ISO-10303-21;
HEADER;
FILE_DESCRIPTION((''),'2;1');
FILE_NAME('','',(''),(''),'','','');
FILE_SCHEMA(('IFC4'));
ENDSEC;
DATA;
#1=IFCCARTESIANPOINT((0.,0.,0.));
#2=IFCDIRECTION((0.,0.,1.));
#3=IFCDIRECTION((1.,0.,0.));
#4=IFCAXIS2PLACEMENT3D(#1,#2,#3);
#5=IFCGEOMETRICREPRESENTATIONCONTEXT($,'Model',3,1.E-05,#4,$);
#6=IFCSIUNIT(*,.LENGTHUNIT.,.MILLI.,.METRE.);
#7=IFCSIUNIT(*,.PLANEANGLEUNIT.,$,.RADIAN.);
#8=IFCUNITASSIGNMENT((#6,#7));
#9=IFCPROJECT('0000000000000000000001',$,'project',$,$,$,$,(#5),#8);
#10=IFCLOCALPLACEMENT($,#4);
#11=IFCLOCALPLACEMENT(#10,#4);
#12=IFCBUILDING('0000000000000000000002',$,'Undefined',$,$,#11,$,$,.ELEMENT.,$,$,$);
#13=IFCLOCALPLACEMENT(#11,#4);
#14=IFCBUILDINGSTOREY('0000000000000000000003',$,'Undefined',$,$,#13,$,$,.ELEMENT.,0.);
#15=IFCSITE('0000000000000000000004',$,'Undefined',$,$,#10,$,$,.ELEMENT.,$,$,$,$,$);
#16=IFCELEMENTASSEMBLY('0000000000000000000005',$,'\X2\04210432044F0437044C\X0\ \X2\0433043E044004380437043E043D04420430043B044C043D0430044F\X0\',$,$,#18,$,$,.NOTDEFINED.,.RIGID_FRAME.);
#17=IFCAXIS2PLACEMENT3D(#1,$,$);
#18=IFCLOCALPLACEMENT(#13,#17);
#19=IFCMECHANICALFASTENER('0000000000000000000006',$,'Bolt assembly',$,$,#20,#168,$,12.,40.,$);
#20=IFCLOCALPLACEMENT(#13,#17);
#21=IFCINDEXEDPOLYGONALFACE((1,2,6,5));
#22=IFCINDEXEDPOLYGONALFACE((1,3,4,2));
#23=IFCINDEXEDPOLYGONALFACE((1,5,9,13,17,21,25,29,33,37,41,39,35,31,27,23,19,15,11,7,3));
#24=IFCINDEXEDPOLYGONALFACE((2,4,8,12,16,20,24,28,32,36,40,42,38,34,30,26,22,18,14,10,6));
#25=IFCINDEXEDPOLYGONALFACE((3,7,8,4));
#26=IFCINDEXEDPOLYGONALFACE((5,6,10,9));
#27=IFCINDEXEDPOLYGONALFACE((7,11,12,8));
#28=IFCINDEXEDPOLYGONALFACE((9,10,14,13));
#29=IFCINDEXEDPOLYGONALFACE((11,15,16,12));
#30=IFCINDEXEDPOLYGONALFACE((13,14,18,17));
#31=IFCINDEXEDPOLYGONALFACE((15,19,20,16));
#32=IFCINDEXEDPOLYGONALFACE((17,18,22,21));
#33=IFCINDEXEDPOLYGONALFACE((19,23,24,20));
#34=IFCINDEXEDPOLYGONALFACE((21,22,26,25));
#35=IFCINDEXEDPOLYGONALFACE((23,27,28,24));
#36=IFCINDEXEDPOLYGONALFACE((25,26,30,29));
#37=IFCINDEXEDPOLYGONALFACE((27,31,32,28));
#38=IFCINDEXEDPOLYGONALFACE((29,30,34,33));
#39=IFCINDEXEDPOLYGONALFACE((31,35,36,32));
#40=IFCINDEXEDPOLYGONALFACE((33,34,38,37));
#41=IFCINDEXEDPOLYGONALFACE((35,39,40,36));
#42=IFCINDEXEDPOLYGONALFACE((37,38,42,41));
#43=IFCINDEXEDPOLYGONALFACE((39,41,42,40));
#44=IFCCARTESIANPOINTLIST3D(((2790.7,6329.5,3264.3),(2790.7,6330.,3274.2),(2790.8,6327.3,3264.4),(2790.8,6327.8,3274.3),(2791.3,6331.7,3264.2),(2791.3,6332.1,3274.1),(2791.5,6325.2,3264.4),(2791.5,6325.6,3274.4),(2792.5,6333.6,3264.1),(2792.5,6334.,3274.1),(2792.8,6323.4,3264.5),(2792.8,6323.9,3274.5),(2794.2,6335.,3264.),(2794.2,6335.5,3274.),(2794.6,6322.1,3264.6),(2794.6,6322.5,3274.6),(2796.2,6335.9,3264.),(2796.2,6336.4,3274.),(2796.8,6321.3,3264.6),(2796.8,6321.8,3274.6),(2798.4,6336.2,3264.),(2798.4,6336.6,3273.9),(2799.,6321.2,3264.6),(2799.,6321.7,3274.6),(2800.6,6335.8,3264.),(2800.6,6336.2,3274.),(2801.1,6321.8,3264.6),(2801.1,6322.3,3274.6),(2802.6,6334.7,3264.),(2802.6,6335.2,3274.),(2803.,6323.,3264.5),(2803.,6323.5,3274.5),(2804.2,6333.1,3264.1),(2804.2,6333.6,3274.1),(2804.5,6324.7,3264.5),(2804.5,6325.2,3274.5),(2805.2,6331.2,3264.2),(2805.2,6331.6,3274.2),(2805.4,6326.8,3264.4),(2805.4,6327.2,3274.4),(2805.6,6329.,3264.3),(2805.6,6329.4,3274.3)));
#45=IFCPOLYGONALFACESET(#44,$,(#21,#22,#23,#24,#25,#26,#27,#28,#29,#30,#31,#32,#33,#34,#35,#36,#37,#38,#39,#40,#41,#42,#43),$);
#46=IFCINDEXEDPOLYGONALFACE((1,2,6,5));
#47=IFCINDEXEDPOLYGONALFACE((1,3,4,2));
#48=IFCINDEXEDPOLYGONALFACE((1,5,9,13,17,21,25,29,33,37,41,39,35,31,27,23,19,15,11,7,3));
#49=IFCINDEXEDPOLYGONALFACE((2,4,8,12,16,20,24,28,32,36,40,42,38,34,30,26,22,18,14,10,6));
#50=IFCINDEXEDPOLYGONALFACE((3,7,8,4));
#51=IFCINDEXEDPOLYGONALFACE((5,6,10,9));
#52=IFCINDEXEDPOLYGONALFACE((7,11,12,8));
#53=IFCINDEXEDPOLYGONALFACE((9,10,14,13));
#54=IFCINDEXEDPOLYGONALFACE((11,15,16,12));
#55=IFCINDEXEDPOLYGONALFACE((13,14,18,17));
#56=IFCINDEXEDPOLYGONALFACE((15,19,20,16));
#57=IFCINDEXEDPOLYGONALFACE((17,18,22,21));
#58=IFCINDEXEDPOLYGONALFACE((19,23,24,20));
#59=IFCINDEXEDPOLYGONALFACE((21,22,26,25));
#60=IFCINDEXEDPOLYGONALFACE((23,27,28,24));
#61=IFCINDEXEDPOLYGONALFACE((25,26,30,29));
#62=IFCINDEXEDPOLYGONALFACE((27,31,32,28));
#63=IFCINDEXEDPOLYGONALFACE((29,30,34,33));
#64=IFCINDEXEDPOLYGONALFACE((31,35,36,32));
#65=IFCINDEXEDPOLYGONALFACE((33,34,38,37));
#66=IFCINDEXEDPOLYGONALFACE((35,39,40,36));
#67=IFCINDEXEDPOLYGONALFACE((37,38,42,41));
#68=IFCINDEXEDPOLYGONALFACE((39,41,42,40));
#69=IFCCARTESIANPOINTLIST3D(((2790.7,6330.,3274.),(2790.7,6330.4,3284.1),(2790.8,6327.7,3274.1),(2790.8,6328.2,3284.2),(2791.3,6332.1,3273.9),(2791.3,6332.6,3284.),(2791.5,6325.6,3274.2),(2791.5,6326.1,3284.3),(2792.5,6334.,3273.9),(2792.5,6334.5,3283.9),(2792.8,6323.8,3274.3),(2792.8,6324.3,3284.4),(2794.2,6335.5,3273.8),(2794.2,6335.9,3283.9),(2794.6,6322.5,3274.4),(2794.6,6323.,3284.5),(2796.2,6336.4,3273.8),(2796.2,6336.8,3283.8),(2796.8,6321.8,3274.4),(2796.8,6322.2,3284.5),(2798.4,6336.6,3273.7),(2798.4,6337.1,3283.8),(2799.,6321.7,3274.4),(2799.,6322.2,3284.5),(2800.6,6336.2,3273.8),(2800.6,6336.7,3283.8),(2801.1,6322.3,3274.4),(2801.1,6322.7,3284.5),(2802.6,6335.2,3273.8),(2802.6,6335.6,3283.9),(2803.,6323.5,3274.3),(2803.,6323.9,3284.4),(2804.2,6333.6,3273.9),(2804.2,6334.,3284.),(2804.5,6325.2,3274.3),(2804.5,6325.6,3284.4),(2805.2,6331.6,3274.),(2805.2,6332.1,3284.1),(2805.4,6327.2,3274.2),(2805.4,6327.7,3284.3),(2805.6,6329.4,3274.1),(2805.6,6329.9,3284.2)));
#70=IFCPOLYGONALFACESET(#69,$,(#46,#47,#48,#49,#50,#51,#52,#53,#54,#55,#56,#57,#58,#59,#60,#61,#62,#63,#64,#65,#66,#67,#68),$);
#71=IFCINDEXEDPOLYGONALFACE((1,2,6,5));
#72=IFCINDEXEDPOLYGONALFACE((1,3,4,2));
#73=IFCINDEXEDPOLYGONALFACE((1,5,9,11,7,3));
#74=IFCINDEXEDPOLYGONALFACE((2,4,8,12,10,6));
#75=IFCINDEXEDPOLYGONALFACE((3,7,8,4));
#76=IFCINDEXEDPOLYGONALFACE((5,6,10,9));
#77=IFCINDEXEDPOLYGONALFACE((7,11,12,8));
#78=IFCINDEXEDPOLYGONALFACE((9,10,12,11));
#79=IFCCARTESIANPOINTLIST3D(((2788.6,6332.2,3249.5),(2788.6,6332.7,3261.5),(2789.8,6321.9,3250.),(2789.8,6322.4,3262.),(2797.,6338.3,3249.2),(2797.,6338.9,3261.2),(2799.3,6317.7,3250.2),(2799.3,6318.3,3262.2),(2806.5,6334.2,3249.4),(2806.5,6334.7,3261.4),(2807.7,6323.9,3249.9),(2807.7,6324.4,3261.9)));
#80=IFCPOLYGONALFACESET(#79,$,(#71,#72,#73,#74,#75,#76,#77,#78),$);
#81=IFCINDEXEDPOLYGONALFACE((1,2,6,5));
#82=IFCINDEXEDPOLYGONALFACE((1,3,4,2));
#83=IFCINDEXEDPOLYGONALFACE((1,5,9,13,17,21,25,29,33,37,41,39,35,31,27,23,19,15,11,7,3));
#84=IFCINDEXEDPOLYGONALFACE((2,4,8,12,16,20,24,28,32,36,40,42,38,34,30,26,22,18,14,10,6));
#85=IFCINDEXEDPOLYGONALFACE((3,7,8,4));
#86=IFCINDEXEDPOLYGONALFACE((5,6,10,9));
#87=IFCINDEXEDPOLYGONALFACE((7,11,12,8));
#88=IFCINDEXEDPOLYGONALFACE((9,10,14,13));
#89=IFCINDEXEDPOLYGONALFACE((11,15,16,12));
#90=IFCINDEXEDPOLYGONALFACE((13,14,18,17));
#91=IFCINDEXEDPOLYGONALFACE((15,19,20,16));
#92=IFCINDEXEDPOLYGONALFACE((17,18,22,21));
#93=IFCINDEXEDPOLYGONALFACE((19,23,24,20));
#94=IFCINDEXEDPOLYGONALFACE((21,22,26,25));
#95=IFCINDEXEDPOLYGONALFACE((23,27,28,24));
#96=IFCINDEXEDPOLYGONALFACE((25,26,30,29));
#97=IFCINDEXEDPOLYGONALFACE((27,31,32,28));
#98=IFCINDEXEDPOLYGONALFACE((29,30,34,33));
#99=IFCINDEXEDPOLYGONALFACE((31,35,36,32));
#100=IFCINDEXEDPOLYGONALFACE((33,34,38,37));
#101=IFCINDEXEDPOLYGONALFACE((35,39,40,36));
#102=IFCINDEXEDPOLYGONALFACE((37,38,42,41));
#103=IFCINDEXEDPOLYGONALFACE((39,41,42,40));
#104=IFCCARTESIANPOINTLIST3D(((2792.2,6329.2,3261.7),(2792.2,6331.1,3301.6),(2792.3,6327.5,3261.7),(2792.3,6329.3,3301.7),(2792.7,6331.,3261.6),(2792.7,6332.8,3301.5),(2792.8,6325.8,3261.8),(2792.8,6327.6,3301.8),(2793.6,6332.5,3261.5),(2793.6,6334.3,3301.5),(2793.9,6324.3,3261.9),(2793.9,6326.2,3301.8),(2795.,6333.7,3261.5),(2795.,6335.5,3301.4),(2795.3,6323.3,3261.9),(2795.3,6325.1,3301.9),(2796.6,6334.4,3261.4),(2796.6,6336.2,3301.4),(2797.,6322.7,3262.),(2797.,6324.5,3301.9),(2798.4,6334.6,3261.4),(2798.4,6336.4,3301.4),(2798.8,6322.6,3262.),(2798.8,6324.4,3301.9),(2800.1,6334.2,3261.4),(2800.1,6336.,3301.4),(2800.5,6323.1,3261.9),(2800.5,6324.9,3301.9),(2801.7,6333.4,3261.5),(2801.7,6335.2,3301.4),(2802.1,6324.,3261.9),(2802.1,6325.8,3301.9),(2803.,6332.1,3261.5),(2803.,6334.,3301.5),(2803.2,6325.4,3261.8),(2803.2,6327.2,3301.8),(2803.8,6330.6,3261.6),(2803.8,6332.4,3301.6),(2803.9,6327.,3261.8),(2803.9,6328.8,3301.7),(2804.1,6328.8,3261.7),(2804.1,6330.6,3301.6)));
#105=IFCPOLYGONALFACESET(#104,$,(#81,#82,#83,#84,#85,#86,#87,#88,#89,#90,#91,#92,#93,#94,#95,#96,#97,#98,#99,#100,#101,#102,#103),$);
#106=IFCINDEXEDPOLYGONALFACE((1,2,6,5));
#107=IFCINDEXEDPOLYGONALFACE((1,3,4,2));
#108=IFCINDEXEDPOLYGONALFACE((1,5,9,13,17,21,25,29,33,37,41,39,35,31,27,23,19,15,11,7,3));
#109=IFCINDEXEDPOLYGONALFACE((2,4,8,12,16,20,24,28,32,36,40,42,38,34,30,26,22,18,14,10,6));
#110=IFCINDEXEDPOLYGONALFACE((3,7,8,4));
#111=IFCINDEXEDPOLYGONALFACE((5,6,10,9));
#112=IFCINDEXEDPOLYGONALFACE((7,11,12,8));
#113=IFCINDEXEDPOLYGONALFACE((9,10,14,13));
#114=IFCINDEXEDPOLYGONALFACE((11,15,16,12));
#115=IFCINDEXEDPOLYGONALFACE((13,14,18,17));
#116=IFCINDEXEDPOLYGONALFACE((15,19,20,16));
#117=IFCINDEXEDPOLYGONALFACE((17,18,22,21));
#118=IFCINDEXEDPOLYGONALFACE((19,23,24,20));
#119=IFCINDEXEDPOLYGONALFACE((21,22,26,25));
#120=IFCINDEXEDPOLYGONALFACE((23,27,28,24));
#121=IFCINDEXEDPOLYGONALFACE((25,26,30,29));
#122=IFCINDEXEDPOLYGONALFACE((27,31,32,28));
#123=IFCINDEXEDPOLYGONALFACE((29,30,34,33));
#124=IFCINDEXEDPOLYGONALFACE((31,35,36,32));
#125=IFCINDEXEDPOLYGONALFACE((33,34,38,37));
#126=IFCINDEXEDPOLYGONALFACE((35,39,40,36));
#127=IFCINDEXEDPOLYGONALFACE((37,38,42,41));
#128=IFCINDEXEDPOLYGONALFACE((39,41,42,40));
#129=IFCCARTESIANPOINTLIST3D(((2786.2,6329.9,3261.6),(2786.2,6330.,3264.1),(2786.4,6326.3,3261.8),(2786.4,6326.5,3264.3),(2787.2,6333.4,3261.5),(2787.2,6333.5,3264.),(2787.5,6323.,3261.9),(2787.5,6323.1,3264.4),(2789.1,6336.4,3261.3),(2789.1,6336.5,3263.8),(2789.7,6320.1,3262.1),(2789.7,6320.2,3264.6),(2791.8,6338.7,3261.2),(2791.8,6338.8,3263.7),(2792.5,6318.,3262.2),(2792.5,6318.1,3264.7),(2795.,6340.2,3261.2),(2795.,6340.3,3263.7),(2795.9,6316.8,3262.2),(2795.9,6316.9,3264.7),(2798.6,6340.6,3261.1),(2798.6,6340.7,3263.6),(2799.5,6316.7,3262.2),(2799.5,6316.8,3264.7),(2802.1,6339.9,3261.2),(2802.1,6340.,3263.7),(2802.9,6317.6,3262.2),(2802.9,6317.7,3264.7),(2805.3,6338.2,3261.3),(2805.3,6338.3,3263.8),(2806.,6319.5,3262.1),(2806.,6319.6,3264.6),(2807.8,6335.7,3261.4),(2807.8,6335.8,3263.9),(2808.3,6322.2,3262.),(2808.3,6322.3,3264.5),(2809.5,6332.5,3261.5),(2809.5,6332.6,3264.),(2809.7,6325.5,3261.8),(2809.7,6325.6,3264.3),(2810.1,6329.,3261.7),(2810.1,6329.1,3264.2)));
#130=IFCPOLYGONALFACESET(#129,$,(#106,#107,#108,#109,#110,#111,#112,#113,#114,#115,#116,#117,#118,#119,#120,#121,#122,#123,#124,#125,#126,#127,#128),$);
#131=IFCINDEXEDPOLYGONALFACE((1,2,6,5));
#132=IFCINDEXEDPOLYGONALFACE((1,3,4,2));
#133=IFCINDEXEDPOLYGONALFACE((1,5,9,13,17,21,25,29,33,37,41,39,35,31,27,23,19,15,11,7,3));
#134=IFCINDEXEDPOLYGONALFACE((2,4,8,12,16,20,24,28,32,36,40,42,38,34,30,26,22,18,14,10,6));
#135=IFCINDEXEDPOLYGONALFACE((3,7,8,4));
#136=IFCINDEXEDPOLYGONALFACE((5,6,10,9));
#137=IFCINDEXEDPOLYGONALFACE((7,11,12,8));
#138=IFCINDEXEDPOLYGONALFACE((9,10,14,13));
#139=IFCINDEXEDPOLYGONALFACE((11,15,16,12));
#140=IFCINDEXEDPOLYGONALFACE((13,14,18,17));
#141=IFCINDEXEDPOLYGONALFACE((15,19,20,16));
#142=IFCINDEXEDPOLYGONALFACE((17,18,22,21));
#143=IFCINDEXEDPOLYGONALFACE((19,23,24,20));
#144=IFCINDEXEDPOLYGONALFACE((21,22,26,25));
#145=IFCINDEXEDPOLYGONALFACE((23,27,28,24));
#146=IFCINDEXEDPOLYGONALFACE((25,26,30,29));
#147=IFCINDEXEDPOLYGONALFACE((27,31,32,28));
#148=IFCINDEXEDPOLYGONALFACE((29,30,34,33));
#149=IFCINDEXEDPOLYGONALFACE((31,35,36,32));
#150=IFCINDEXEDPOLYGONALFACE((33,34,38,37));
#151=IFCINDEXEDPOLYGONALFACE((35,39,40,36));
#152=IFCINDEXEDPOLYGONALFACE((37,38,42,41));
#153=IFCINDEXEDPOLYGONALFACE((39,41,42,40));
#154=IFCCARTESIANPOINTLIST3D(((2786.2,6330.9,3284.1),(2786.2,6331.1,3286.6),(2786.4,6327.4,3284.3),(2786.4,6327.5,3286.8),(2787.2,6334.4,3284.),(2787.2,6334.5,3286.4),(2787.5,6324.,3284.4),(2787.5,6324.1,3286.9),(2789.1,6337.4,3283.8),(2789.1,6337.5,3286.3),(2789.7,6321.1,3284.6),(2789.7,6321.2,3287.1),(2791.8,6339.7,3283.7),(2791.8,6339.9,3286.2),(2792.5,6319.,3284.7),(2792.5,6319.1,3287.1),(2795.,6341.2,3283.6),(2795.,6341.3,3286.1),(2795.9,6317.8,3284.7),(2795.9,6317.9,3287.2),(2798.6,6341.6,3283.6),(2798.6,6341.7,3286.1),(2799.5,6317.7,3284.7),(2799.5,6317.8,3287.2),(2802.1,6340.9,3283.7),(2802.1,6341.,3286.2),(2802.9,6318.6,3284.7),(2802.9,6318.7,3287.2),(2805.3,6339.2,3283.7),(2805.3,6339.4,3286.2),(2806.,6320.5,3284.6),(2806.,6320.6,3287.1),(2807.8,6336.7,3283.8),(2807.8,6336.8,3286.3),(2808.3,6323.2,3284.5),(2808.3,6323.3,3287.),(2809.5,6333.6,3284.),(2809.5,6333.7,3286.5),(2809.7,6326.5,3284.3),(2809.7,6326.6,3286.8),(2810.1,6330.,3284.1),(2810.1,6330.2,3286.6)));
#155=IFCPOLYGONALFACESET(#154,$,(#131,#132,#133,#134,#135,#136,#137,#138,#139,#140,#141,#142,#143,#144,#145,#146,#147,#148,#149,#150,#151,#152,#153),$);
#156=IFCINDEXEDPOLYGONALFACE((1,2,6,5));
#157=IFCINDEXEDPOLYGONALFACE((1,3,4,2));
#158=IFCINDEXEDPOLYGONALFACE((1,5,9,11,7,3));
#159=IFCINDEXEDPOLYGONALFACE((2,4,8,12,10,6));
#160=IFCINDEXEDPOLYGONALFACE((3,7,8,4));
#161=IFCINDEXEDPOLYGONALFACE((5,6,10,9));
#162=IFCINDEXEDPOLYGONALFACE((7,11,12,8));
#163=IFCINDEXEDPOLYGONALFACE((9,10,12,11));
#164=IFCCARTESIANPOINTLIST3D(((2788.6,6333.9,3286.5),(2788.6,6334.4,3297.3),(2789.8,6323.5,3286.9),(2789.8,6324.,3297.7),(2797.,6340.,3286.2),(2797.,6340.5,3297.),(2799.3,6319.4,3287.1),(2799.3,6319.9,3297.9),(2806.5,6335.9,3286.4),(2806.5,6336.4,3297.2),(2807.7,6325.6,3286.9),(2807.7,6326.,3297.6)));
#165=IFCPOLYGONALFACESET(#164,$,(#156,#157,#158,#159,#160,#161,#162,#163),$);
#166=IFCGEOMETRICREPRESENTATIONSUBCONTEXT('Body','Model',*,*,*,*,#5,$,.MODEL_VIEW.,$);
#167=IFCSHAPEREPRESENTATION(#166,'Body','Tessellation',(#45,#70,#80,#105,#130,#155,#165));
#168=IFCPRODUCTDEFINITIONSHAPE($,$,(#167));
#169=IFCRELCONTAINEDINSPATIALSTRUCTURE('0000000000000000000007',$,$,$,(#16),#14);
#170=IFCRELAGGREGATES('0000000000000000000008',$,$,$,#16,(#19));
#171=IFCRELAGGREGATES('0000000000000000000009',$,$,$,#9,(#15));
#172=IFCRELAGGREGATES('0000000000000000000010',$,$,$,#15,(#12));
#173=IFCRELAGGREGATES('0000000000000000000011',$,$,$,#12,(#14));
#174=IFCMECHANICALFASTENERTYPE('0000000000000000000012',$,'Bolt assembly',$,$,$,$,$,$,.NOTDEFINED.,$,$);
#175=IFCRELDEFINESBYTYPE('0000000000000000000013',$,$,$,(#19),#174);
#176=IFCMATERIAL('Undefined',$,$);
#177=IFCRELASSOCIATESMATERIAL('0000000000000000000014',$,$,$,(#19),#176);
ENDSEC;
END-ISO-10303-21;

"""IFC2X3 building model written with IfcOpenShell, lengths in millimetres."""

from ifc_helpers import new_model, si_unit, frame, origin_with_axes, origin_2d_with_axis, place, context, subcontext, project, spatial, polyline, circle, outline, extrude, source, transform, mapped, material, type_object, element, aggregate, save


model = new_model("IFC2X3")

# Units and contexts
model_context = context("Model", 3, precision=1e-05, world=origin_with_axes())
body_context = subcontext(model_context, "Body", "Model", "MODEL_VIEW")
ifc_project = project(units=[si_unit("LENGTHUNIT", "METRE", prefix="MILLI"), si_unit("PLANEANGLEUNIT", "RADIAN")], contexts=[model_context])

# Site, building, storey
site_placement = place(None, origin_with_axes())
site = spatial("IfcSite", under=ifc_project, at=site_placement, Name="Undefined", CompositionType="ELEMENT")
building_placement = place(site_placement, origin_with_axes())
building = spatial("IfcBuilding", under=site, at=building_placement, Name="Undefined", CompositionType="ELEMENT")
storey_placement = place(building_placement, origin_with_axes())
storey = spatial("IfcBuildingStorey", under=building, at=storey_placement, Name="Undefined", CompositionType="ELEMENT", Elevation=0.0)

# Element assembly
assembly_1_placement = place(storey_placement, origin_with_axes())
assembly_1 = element("IfcElementAssembly", 1, at=assembly_1_placement, inside=storey, Name="Связь горизонтальная", AssemblyPlace="NOTDEFINED", PredefinedType="RIGID_FRAME")

# Mechanical fastener
ifc_material_1 = material(Name="Undefined")
mechanical_fastener_type = type_object("IfcMechanicalFastenerType", Name="Bolt assembly")
shared_shape_1 = source(origin_with_axes(), body_context, "Body", "SweptSolid", [
    extrude(circle(Radius=7.5, at=origin_2d_with_axis()), frame((0.0, 0.1, 0.0), z_axis=(0.0, 1.0, 0.0), x_axis=(1.0, 0.0, 0.0)), (0.0, 0.0, 1.0), 10.0),
    extrude(circle(Radius=7.5, at=origin_2d_with_axis()), frame((0.0, 9.9, 0.0), z_axis=(0.0, 1.0, 0.0), x_axis=(1.0, 0.0, 0.0)), (0.0, 0.0, 1.0), 10.1),
    extrude(outline(polyline([(10.4, 0.0), (5.2, 9.0), (-5.2, 9.0), (-10.4, 0.0), (-5.2, -9.0), (5.2, -9.0), (10.4, 0.0)])), frame((0.0, -14.5, 0.0), z_axis=(0.0, 1.0, 0.0), x_axis=(1.0, 0.0, 0.0)), (0.0, 0.0, 1.0), 12.0),
    extrude(circle(Radius=6.0, at=origin_2d_with_axis()), frame((0.0, -2.5, 0.0), z_axis=(0.0, 1.0, 0.0), x_axis=(1.0, 0.0, 0.0)), (0.0, 0.0, 1.0), 40.0),
    extrude(circle(Radius=12.0, at=origin_2d_with_axis()), frame((0.0, -2.5, 0.0), z_axis=(0.0, 1.0, 0.0), x_axis=(1.0, 0.0, 0.0)), (0.0, 0.0, 1.0), 2.5),
    extrude(circle(Radius=12.0, at=origin_2d_with_axis()), frame((0.0, 20.0, 0.0), z_axis=(0.0, 1.0, 0.0), x_axis=(1.0, 0.0, 0.0)), (0.0, 0.0, 1.0), 2.5),
    extrude(outline(polyline([(10.4, 0.0), (5.2, 9.0), (-5.2, 9.0), (-10.4, 0.0), (-5.2, -9.0), (5.2, -9.0), (10.4, 0.0)])), frame((0.0, 22.5, 0.0), z_axis=(0.0, 1.0, 0.0), x_axis=(1.0, 0.0, 0.0)), (0.0, 0.0, 1.0), 10.8),
])
mechanical_fastener_1_placement = place(assembly_1_placement, frame((2798.1, 6328.7, 3264.2), z_axis=(0.593795, -0.803786, 0.036536), x_axis=(0.804616, 0.593183, -0.026963)))
mechanical_fastener_1 = element("IfcMechanicalFastener", 2, at=mechanical_fastener_1_placement, type_object=mechanical_fastener_type, material=ifc_material_1, Name="Bolt assembly", NominalDiameter=12.0, NominalLength=40.0, context=body_context, shape_type="MappedRepresentation", body=[
    mapped(shared_shape_1, transform((0.0, 0.0, 0.0))),
])
aggregate(assembly_1, [mechanical_fastener_1])

save(model, "model.ifc")
